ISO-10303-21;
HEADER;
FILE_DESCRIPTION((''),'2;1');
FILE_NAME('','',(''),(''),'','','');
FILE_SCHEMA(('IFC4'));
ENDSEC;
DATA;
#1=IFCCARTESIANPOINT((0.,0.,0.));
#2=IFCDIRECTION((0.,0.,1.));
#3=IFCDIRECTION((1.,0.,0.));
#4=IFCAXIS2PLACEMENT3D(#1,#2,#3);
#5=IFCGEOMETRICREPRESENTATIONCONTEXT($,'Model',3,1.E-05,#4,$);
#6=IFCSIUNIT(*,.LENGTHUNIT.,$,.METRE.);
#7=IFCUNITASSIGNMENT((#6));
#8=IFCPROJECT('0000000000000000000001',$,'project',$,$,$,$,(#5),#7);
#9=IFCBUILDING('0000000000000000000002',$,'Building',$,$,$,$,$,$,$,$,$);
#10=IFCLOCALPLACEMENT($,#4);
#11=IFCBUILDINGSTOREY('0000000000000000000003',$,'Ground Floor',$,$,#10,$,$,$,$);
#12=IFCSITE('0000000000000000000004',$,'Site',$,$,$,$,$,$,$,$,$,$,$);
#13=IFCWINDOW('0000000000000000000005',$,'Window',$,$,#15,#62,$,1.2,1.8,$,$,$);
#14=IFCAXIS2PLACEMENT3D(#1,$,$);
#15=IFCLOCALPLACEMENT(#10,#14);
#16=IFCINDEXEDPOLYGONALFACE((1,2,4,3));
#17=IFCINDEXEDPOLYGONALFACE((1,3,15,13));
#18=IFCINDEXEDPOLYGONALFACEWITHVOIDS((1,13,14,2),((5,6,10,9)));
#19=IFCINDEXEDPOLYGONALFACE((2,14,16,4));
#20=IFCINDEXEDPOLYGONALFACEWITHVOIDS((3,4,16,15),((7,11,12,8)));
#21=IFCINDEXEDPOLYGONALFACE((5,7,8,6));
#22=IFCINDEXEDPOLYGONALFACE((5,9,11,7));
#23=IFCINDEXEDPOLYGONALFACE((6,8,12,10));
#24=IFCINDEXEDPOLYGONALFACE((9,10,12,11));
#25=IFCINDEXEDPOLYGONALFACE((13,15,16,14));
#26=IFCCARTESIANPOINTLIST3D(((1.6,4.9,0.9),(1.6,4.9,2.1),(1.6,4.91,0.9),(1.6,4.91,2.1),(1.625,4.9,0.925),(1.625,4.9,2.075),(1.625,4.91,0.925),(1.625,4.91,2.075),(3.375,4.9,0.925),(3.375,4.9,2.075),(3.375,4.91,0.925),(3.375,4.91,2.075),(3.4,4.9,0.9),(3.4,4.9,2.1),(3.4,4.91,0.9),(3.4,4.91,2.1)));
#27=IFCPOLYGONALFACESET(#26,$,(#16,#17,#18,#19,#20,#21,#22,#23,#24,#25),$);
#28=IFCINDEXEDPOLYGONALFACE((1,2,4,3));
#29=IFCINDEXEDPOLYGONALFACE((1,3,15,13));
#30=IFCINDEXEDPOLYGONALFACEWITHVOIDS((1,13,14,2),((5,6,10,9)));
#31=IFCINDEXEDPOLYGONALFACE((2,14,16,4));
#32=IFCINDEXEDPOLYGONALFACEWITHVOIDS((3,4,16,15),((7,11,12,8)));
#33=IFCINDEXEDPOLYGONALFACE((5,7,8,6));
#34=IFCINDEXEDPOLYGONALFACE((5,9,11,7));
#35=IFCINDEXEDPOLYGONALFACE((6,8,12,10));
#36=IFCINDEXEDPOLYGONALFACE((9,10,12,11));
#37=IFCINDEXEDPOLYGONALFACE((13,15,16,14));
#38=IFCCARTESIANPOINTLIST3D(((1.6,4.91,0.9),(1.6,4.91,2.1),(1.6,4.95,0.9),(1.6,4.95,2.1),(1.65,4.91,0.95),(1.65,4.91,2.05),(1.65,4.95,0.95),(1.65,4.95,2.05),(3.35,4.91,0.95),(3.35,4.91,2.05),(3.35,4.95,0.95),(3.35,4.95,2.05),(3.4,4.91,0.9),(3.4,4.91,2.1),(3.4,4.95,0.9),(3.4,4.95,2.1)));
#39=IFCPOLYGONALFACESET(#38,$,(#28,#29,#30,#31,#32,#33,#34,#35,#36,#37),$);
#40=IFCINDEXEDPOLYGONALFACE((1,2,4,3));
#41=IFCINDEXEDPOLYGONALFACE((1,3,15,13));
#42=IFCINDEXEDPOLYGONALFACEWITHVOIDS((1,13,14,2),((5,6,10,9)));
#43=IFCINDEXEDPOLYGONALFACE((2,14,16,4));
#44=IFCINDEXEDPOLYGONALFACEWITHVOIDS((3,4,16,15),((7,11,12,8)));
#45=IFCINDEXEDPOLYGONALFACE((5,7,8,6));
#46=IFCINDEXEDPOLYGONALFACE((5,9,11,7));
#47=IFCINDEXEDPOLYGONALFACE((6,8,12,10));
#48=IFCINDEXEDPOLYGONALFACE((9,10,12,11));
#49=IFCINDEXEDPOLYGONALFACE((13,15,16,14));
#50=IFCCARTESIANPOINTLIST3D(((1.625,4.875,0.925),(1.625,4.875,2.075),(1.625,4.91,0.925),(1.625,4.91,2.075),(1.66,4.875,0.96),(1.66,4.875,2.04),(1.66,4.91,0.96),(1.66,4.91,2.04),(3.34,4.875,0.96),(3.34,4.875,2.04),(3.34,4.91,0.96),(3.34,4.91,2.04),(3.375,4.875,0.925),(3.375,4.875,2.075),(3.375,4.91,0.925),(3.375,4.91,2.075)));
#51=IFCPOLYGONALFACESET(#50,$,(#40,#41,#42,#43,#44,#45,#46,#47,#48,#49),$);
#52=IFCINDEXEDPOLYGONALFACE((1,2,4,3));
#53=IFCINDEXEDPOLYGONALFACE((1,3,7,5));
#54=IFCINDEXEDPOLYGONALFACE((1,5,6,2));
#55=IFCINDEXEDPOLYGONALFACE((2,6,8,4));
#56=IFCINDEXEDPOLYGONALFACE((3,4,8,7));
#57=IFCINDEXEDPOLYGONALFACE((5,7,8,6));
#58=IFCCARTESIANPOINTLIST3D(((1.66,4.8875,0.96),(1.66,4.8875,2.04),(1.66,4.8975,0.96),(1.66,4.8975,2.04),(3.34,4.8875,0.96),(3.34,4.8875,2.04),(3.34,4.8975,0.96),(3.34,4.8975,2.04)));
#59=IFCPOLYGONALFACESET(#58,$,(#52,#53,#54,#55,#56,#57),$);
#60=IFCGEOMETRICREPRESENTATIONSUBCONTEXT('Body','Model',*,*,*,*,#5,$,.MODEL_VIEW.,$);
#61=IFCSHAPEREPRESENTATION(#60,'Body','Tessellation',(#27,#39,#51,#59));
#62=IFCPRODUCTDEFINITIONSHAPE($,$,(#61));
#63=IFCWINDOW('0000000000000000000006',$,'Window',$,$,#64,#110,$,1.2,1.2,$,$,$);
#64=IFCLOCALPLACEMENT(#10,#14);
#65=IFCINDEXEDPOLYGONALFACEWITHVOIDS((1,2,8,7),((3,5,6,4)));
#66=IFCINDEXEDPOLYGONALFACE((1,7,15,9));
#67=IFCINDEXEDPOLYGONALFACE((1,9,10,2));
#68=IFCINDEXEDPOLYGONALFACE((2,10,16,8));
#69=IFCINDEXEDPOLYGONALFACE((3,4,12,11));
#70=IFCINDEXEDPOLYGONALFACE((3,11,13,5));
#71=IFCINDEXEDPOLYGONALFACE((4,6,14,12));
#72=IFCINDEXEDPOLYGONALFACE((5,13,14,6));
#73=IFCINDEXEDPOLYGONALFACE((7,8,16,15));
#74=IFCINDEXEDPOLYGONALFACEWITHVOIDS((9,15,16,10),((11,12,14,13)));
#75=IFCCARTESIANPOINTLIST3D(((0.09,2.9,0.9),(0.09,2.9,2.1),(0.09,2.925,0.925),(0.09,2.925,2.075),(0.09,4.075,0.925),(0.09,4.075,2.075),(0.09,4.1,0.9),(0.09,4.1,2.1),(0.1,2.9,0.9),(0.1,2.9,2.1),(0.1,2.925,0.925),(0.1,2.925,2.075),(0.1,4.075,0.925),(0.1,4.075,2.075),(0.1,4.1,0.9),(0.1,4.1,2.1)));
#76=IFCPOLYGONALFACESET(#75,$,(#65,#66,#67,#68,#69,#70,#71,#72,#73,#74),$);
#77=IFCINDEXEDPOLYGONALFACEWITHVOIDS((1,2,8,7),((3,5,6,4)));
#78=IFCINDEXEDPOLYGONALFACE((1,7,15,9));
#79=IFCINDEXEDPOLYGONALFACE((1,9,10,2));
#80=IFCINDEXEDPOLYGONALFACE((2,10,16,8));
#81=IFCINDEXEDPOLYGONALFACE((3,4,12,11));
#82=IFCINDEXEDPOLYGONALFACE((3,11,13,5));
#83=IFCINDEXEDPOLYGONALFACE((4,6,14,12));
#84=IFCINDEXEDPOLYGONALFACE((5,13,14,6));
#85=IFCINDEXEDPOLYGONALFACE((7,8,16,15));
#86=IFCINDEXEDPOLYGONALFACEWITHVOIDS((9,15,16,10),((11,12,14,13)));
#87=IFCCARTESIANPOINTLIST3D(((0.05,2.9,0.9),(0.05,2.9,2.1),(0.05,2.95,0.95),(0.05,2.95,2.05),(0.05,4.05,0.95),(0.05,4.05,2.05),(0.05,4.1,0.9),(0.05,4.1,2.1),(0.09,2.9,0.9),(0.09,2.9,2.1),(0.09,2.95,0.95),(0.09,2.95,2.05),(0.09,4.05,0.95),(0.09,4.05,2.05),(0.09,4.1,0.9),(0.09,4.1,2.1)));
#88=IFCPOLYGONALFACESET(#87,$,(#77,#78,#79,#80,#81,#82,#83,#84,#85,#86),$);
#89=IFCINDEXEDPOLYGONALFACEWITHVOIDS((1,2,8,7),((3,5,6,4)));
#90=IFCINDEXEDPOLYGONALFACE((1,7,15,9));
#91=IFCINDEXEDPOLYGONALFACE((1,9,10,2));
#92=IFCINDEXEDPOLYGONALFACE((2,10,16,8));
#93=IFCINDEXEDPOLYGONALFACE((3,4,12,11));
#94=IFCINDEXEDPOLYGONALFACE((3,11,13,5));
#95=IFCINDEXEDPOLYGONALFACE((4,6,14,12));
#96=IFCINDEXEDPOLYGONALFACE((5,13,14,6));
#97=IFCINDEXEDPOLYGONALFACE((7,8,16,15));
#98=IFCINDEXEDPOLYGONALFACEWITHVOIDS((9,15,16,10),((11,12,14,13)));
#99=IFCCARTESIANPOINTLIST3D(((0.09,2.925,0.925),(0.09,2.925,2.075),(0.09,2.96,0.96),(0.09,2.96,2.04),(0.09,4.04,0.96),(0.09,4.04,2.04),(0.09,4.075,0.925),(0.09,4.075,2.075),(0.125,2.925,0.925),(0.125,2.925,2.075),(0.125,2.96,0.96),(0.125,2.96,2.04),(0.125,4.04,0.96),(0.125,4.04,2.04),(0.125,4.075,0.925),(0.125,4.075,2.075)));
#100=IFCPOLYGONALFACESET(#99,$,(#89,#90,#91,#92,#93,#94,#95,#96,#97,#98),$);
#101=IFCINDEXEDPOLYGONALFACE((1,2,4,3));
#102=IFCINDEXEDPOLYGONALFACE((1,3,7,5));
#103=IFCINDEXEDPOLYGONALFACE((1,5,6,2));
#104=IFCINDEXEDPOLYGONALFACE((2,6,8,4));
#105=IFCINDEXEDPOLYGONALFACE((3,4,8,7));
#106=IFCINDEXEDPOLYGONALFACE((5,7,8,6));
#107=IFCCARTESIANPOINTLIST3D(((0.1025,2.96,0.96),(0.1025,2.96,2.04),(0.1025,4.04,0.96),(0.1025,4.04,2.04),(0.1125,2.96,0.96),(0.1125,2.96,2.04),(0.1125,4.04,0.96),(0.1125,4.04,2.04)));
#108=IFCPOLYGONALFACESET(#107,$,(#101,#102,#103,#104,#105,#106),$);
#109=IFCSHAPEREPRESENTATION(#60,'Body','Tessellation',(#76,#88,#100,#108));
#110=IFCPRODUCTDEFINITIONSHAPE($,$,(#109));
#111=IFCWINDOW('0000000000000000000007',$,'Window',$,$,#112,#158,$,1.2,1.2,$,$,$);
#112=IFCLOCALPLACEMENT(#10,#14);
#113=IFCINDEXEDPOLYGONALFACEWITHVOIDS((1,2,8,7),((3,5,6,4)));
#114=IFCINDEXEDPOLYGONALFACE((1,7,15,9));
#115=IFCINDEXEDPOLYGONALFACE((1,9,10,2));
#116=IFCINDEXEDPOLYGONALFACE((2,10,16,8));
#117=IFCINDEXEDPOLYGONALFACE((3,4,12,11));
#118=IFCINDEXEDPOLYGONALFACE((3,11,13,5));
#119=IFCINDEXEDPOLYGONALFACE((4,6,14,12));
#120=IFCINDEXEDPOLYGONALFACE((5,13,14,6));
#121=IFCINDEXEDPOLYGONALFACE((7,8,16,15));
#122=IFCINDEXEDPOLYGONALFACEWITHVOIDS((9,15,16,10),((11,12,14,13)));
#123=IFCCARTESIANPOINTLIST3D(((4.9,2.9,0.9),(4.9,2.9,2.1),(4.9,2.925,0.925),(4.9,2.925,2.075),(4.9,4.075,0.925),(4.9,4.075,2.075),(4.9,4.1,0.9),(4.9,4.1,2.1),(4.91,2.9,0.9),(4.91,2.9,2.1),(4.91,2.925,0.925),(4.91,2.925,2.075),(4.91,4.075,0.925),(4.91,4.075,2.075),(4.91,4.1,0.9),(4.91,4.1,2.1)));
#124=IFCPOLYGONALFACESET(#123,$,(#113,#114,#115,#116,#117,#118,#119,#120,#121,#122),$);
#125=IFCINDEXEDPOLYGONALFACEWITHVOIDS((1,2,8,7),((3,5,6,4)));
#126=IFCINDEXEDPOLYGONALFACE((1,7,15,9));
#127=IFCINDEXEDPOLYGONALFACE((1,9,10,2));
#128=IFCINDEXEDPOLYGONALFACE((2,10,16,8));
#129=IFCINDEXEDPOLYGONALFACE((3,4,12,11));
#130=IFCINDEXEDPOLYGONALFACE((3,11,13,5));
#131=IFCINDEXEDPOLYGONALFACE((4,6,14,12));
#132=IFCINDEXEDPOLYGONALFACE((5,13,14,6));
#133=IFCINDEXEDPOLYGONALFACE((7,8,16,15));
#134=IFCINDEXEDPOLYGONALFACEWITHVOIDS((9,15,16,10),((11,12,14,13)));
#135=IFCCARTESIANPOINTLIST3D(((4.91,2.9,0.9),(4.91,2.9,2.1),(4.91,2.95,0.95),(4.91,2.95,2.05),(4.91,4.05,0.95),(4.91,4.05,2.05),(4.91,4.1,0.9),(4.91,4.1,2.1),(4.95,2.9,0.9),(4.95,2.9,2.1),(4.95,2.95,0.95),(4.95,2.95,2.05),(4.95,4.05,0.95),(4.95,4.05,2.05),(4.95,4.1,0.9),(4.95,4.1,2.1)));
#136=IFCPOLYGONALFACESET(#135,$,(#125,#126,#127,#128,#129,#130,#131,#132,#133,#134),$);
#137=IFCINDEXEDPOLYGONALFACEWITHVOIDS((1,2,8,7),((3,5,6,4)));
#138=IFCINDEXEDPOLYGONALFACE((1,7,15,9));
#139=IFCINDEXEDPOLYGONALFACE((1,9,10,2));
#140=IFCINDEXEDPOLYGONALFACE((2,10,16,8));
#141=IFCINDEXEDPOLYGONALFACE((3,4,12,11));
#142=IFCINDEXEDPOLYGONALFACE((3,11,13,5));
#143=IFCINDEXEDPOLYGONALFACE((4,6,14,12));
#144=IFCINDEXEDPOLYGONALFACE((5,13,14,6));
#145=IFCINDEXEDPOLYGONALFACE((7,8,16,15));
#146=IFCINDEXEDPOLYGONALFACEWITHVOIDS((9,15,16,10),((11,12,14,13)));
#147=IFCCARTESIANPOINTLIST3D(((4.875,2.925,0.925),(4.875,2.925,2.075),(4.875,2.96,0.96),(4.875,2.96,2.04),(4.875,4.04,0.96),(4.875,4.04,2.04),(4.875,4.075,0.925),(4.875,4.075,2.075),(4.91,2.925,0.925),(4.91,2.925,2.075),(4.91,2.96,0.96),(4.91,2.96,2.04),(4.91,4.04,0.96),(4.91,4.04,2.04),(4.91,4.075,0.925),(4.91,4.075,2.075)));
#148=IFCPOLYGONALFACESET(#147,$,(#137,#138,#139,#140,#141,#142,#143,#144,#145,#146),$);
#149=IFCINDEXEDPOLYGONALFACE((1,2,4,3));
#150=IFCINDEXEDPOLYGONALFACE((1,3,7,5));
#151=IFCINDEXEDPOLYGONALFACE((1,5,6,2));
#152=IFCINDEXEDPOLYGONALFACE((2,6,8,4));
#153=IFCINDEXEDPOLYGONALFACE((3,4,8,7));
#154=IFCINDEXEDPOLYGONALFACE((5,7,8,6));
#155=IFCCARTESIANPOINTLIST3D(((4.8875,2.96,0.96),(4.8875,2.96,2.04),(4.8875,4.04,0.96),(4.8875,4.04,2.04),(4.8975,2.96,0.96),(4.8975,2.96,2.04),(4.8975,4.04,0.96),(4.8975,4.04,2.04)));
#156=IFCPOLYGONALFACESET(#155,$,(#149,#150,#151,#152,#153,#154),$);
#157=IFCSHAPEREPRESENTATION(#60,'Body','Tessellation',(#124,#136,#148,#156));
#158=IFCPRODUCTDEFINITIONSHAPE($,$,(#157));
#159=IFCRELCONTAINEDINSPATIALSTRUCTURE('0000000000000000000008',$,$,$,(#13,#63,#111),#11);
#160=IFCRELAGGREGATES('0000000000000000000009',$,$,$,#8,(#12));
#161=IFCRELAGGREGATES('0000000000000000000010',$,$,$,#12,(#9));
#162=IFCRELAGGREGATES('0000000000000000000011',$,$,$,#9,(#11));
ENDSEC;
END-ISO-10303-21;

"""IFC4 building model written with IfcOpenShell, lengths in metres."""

from ifc_helpers import new_model, si_unit, frame, origin_with_axes, place, context, subcontext, project, spatial, line, indexed_curve, outline, extrude, element, save


model = new_model("IFC4")

# Units and contexts
model_context = context("Model", 3, precision=1e-05, world=origin_with_axes())
body_context = subcontext(model_context, "Body", "Model", "MODEL_VIEW")
ifc_project = project(units=[si_unit("LENGTHUNIT", "METRE")], contexts=[model_context])

# Site, building, storey
site = spatial("IfcSite", under=ifc_project, Name="Site")
building = spatial("IfcBuilding", under=site, Name="Building")
storey_placement = place(None, origin_with_axes())
storey = spatial("IfcBuildingStorey", under=building, at=storey_placement, Name="Ground Floor")

# Windows
window_placement = place(storey_placement, frame((3.4, 5.0, 0.9), z_axis=(0.0, 0.0, 1.0), x_axis=(-1.0, 0.0, 0.0)))
element("IfcWindow", 1, at=window_placement, inside=storey, Name="Window", OverallHeight=1.2, OverallWidth=1.8, context=body_context, shape_type="SweptSolid", body=[
    extrude(outline(indexed_curve([(0.0, 0.0), (1.8, 0.0), (1.8, 1.2), (0.0, 1.2)], segments=[line(1, 2, 3, 4, 1)]), holes=[indexed_curve([(0.025, 0.025), (1.775, 0.025), (1.775, 1.175), (0.025, 1.175)], segments=[line(1, 2, 3, 4, 1)])]), frame((0.0, 0.09, 0.0), z_axis=(0.0, -1.0, 0.0), x_axis=(1.0, 0.0, 0.0)), (0.0, 0.0, -1.0), 0.01),
    extrude(outline(indexed_curve([(0.0, 0.0), (1.8, 0.0), (1.8, 1.2), (0.0, 1.2)], segments=[line(1, 2, 3, 4, 1)]), holes=[indexed_curve([(0.05, 0.05), (1.75, 0.05), (1.75, 1.15), (0.05, 1.15)], segments=[line(1, 2, 3, 4, 1)])]), frame((0.0, 0.05, 0.0), z_axis=(0.0, -1.0, 0.0), x_axis=(1.0, 0.0, 0.0)), (0.0, 0.0, -1.0), 0.04),
    extrude(outline(indexed_curve([(0.0, 0.0), (1.75, 0.0), (1.75, 1.15), (0.0, 1.15)], segments=[line(1, 2, 3, 4, 1)]), holes=[indexed_curve([(0.035, 0.035), (1.715, 0.035), (1.715, 1.115), (0.035, 1.115)], segments=[line(1, 2, 3, 4, 1)])]), frame((0.025, 0.09, 0.025), z_axis=(0.0, -1.0, 0.0), x_axis=(1.0, 0.0, 0.0)), (0.0, 0.0, -1.0), 0.035),
    extrude(outline(indexed_curve([(0.035, 0.035), (1.715, 0.035), (1.715, 1.115), (0.035, 1.115)], segments=[line(1, 2, 3, 4, 1)])), frame((0.025, 0.1025, 0.025), z_axis=(0.0, -1.0, 0.0), x_axis=(1.0, 0.0, 0.0)), (0.0, 0.0, -1.0), 0.01),
])
for number, where, z_axis, x_axis, name in (
    (2, (0.0, 4.1, 0.9), (0.0, 0.0, 1.0), (0.0, -1.0, 0.0), "Window"),
    (3, (5.0, 2.9, 0.9), (0.0, 0.0, 1.0), (0.0, 1.0, 0.0), "Window"),
):
    element("IfcWindow", number, at=place(storey_placement, frame(where, z_axis=z_axis, x_axis=x_axis)), inside=storey, Name=name, OverallHeight=1.2, OverallWidth=1.2, context=body_context, shape_type="SweptSolid", body=[
        extrude(outline(indexed_curve([(0.0, 0.0), (1.2, 0.0), (1.2, 1.2), (0.0, 1.2)], segments=[line(1, 2, 3, 4, 1)]), holes=[indexed_curve([(0.025, 0.025), (1.175, 0.025), (1.175, 1.175), (0.025, 1.175)], segments=[line(1, 2, 3, 4, 1)])]), frame((0.0, 0.09, 0.0), z_axis=(0.0, -1.0, 0.0), x_axis=(1.0, 0.0, 0.0)), (0.0, 0.0, -1.0), 0.01),
        extrude(outline(indexed_curve([(0.0, 0.0), (1.2, 0.0), (1.2, 1.2), (0.0, 1.2)], segments=[line(1, 2, 3, 4, 1)]), holes=[indexed_curve([(0.05, 0.05), (1.15, 0.05), (1.15, 1.15), (0.05, 1.15)], segments=[line(1, 2, 3, 4, 1)])]), frame((0.0, 0.05, 0.0), z_axis=(0.0, -1.0, 0.0), x_axis=(1.0, 0.0, 0.0)), (0.0, 0.0, -1.0), 0.04),
        extrude(outline(indexed_curve([(0.0, 0.0), (1.15, 0.0), (1.15, 1.15), (0.0, 1.15)], segments=[line(1, 2, 3, 4, 1)]), holes=[indexed_curve([(0.035, 0.035), (1.115, 0.035), (1.115, 1.115), (0.035, 1.115)], segments=[line(1, 2, 3, 4, 1)])]), frame((0.025, 0.09, 0.025), z_axis=(0.0, -1.0, 0.0), x_axis=(1.0, 0.0, 0.0)), (0.0, 0.0, -1.0), 0.035),
        extrude(outline(indexed_curve([(0.035, 0.035), (1.115, 0.035), (1.115, 1.115), (0.035, 1.115)], segments=[line(1, 2, 3, 4, 1)])), frame((0.025, 0.1025, 0.025), z_axis=(0.0, -1.0, 0.0), x_axis=(1.0, 0.0, 0.0)), (0.0, 0.0, -1.0), 0.01),
    ])

save(model, "model.ifc")
